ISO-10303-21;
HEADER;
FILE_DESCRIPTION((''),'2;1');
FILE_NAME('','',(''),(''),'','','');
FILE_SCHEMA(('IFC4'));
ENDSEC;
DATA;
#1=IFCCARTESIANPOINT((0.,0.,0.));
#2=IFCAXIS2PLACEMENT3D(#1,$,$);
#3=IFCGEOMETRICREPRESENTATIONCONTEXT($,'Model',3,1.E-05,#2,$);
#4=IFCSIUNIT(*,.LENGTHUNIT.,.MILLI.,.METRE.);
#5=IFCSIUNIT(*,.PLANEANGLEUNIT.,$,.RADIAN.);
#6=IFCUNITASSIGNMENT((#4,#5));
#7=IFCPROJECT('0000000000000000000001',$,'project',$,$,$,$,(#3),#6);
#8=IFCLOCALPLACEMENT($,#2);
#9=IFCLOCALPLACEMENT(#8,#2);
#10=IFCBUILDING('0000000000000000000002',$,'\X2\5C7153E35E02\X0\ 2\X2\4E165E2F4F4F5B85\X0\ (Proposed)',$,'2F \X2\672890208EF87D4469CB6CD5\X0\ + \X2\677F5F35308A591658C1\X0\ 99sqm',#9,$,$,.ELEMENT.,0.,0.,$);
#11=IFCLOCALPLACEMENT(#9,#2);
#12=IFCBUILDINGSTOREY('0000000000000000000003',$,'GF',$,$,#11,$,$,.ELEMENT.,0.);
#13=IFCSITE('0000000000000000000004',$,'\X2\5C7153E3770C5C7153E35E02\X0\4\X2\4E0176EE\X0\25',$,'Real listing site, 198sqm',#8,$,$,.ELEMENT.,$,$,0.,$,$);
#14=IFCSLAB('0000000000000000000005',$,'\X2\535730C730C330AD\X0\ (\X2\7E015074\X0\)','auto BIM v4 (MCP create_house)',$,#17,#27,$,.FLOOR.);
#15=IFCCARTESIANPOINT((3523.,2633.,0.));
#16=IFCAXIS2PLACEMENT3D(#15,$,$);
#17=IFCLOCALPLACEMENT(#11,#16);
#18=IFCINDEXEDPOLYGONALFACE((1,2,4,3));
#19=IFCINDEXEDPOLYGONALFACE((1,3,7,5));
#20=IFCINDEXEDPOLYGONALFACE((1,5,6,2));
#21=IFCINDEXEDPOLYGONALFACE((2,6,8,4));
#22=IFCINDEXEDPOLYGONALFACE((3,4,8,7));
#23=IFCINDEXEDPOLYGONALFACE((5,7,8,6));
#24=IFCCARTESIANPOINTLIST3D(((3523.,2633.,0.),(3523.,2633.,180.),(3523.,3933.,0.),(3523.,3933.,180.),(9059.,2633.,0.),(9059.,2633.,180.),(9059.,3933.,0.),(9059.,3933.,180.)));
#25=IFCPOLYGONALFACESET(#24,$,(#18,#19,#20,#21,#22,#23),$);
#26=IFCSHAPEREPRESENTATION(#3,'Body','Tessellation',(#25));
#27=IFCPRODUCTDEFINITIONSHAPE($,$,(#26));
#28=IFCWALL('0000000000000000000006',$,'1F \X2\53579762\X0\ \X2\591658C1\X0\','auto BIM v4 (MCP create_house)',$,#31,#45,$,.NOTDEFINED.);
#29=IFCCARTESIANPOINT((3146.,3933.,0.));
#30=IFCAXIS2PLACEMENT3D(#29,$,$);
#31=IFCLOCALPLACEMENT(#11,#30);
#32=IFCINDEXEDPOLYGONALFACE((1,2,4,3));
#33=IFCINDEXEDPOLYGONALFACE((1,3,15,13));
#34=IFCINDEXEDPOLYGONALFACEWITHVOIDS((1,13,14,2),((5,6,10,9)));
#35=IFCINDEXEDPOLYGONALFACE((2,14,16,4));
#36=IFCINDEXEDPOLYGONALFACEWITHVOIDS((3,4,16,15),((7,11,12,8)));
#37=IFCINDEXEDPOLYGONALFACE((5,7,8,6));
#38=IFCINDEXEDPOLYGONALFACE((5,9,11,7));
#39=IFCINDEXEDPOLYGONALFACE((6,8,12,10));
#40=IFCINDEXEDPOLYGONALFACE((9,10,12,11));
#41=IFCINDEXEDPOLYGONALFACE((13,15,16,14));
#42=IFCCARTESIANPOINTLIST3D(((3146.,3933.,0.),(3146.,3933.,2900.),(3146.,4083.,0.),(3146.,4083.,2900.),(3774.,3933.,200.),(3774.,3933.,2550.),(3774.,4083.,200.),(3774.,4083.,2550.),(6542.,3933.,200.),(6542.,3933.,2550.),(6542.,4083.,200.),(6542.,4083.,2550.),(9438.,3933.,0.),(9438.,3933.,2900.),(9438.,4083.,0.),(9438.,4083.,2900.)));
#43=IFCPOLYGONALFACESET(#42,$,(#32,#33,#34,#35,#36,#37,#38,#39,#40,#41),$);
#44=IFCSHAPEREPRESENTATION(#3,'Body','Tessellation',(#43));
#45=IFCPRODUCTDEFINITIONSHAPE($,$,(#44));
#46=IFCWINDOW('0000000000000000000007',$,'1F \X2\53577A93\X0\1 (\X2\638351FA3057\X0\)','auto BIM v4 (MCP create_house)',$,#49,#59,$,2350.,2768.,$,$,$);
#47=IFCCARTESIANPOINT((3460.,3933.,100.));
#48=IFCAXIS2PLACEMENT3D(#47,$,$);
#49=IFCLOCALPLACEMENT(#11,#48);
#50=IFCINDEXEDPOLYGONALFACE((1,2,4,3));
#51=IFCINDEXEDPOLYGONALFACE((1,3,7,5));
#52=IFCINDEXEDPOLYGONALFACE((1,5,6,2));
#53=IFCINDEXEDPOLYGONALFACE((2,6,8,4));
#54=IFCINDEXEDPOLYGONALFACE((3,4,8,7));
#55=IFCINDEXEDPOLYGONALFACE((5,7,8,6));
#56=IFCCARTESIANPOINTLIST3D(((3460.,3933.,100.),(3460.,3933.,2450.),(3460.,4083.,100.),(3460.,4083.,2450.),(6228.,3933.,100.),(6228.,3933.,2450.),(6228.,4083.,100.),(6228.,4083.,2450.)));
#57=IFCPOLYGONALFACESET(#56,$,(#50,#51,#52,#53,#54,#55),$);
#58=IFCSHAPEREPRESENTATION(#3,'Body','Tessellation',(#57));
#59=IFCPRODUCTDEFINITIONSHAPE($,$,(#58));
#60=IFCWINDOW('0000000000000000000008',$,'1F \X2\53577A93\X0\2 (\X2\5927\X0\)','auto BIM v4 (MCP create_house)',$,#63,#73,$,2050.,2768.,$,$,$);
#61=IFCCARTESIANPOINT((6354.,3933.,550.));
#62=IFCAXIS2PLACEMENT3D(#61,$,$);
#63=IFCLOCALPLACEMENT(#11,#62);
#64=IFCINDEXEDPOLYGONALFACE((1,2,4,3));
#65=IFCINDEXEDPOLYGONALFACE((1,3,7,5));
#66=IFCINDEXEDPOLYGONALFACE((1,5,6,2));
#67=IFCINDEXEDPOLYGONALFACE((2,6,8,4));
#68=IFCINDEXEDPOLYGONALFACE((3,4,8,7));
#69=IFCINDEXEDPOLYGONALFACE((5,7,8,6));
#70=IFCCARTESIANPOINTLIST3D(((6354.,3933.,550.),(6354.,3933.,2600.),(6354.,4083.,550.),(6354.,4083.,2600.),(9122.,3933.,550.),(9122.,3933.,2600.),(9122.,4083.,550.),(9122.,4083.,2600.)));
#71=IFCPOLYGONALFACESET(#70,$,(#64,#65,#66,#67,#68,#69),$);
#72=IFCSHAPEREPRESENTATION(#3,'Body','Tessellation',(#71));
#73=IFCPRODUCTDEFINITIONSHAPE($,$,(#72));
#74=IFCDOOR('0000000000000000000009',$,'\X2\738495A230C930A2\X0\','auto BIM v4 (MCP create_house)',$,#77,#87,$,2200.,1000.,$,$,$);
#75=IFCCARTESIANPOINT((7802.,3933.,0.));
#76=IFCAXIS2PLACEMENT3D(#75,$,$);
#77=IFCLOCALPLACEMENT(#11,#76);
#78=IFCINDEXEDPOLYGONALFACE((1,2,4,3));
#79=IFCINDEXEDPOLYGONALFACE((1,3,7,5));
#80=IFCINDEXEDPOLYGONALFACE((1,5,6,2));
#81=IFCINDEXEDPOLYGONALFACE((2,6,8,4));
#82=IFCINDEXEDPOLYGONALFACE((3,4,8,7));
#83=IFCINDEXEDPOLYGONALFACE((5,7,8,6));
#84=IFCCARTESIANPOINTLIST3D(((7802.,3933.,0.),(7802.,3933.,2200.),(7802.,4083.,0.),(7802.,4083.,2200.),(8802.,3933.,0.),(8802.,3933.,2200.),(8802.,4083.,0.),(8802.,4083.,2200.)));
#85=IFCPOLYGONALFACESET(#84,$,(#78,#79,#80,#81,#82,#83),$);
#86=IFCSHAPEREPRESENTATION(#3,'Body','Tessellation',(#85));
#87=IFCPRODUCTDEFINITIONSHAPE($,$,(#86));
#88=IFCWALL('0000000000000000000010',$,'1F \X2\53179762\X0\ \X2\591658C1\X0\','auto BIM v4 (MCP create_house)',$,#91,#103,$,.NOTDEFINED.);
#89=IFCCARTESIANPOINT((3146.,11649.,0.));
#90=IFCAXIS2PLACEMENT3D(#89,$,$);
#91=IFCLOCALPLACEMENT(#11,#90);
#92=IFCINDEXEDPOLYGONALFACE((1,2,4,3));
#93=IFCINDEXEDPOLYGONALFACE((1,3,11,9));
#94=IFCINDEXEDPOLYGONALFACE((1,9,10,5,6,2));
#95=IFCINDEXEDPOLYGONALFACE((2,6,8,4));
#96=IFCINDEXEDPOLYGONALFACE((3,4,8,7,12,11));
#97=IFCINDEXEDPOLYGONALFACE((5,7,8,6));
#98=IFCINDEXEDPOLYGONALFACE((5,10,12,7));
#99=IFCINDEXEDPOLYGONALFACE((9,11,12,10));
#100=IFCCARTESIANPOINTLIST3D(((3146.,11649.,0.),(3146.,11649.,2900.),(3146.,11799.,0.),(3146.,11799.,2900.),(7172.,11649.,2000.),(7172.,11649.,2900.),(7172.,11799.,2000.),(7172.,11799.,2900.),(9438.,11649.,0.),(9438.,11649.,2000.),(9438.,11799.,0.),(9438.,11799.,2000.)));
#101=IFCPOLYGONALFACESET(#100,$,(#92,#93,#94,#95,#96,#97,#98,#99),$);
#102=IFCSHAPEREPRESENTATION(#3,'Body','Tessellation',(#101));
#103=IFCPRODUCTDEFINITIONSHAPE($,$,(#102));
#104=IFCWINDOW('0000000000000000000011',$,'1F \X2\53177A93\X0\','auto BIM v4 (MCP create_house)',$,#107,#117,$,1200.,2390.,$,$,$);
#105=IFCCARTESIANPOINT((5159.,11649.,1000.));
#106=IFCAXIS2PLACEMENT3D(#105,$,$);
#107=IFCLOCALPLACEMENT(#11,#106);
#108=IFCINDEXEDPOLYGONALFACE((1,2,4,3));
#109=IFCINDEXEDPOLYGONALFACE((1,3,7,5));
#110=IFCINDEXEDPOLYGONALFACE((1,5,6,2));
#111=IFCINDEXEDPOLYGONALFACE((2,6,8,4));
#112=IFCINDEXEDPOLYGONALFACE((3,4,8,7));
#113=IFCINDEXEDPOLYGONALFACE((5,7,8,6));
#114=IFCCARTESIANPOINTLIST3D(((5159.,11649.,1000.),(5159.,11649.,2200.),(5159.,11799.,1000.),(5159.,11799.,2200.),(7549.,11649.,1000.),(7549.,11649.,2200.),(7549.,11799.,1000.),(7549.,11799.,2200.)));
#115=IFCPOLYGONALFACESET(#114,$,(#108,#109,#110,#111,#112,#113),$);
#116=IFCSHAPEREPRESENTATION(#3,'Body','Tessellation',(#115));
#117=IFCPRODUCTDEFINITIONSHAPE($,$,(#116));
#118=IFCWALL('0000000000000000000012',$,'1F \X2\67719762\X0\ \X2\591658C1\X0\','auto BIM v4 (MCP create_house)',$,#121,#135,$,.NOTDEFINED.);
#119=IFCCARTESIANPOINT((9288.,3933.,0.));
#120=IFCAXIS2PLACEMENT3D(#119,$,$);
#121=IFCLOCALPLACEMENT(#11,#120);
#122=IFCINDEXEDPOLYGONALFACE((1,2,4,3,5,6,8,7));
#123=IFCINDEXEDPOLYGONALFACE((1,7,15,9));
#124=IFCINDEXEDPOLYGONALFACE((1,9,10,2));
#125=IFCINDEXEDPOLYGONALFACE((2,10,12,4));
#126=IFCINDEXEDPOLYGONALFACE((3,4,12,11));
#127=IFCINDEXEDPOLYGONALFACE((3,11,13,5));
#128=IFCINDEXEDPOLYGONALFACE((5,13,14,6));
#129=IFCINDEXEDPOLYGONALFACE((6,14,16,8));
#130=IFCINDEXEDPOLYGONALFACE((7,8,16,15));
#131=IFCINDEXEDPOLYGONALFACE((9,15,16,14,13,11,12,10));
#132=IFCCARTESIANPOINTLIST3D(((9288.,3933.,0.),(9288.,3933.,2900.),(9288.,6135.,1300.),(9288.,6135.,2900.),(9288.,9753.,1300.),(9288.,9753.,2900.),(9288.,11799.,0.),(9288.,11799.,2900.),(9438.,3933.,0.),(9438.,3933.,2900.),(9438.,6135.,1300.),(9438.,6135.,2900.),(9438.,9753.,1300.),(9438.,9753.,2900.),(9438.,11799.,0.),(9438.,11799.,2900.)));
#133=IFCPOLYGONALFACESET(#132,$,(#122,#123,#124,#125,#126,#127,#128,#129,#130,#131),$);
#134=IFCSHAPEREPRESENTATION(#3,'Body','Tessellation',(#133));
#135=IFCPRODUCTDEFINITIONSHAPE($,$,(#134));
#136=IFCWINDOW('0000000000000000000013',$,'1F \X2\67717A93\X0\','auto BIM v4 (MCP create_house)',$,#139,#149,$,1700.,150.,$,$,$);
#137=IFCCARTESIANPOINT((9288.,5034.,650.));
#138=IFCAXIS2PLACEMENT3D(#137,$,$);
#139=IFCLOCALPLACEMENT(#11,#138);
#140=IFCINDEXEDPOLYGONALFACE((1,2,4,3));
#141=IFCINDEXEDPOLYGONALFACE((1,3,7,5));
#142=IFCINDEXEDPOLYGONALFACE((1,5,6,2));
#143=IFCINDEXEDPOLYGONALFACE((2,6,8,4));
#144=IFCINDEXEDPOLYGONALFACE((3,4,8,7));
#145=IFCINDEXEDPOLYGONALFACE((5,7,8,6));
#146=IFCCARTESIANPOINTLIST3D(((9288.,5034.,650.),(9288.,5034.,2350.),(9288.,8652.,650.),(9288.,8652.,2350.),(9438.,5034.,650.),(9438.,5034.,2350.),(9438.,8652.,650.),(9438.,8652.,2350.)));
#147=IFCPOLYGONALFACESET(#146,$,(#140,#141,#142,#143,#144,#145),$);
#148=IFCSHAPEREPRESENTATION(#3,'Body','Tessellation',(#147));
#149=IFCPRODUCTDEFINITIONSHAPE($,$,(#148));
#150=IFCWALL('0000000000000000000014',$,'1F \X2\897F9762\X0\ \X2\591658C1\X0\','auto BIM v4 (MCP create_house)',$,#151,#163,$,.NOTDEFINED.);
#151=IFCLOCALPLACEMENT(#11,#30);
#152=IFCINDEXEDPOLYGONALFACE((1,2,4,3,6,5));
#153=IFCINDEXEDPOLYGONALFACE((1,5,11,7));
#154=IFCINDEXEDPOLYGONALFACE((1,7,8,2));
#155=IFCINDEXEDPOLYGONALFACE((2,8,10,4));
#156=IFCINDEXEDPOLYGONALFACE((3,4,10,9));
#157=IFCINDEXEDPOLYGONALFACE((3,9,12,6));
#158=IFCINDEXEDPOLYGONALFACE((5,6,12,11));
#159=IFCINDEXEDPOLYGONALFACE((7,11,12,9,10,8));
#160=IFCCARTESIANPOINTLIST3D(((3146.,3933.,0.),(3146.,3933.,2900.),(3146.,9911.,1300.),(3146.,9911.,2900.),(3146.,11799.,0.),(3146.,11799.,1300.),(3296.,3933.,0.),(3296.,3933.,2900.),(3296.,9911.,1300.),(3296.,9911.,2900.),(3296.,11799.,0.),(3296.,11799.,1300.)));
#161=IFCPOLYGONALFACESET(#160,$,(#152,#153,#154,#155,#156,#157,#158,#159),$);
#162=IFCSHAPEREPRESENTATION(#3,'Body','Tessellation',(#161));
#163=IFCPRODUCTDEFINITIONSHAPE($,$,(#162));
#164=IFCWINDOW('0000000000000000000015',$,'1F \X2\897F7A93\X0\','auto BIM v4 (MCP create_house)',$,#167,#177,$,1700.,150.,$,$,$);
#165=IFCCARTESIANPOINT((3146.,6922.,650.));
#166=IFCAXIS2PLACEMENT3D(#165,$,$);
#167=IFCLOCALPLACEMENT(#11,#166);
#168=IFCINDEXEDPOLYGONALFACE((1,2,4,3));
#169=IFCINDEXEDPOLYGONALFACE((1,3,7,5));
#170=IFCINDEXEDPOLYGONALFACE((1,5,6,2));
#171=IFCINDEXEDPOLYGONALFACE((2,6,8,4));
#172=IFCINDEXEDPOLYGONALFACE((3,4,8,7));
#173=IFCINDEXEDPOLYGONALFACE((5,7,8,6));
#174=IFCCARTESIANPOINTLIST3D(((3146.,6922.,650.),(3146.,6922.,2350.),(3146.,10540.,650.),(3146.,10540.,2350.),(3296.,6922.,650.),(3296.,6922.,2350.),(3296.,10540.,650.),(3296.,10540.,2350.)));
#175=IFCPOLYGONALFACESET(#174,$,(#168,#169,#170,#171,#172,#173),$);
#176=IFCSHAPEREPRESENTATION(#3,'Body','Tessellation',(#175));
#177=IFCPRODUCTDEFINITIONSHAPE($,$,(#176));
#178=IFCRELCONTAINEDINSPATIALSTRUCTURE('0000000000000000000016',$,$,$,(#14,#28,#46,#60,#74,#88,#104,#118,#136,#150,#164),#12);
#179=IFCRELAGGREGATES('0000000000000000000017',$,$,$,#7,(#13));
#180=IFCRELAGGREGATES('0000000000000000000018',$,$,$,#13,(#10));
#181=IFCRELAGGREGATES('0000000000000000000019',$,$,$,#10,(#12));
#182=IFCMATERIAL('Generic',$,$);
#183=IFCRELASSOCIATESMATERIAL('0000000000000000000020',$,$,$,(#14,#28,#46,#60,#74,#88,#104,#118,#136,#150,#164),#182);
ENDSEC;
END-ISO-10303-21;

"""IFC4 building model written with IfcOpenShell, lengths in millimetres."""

from ifc_helpers import new_model, si_unit, frame, frame_2d, origin, place, context, project, spatial, rectangle, extrude, material, element, fill, save


model = new_model("IFC4")

# Units and contexts
model_context = context("Model", 3, precision=1e-05, world=origin())
ifc_project = project(units=[si_unit("LENGTHUNIT", "METRE", prefix="MILLI"), si_unit("PLANEANGLEUNIT", "RADIAN")], contexts=[model_context])

# Site, building, storey
site_placement = place(None, origin())
site = spatial("IfcSite", under=ifc_project, at=site_placement, Name="山口県山口市4丁目25", ObjectType="Real listing site, 198sqm", CompositionType="ELEMENT", RefElevation=0.0)
building_placement = place(site_placement, origin())
building = spatial("IfcBuilding", under=site, at=building_placement, Name="山口市 2世帯住宅 (Proposed)", ObjectType="2F 木造軸組構法 + 板張り外壁 99sqm", CompositionType="ELEMENT", ElevationOfRefHeight=0.0, ElevationOfTerrain=0.0)
storey_placement = place(building_placement, origin())
storey = spatial("IfcBuildingStorey", under=building, at=storey_placement, Name="GF", CompositionType="ELEMENT", Elevation=0.0)

# Slab
ifc_material = material(Name="Generic")
slab_1_placement = place(storey_placement, frame((3523.0, 2633.0, 0.0)))
element("IfcSlab", 1, at=slab_1_placement, inside=storey, material=ifc_material, Name="南デッキ (縁側)", Description="auto BIM v4 (MCP create_house)", PredefinedType="FLOOR", context=model_context, shape_type="SweptSolid", body=[
    extrude(rectangle(XDim=5536.0, YDim=1300.0, at=frame_2d((2768.0, 650.0))), frame((3523.0, 2633.0, 0.0)), (0.0, 0.0, 1.0), 180.0),
])

# Wall, openings, windows, door
wall_1_placement = place(storey_placement, frame((3146.0, 3933.0, 0.0)))
wall_1 = element("IfcWall", 2, at=wall_1_placement, inside=storey, material=ifc_material, Name="1F 南面 外壁", Description="auto BIM v4 (MCP create_house)", PredefinedType="NOTDEFINED", context=model_context, shape_type="SweptSolid", body=[
    extrude(rectangle(XDim=6292.0, YDim=150.0, at=frame_2d((3146.0, 75.0))), frame((3146.0, 3933.0, 0.0)), (0.0, 0.0, 1.0), 2900.0),
])
opening_1_placement = place(storey_placement, frame((3460.0, 3933.0, 100.0)))
opening_1 = element("IfcOpeningElement", 3, at=opening_1_placement, cuts=wall_1, PredefinedType="NOTDEFINED", context=model_context, shape_type="SweptSolid", body=[
    extrude(rectangle(XDim=2768.0, YDim=150.0, at=frame_2d((1384.0, 75.0))), frame((3460.0, 3933.0, 100.0)), (0.0, 0.0, 1.0), 2350.0),
])
opening_2_placement = place(storey_placement, frame((6354.0, 3933.0, 550.0)))
opening_2 = element("IfcOpeningElement", 4, at=opening_2_placement, cuts=wall_1, PredefinedType="NOTDEFINED", context=model_context, shape_type="SweptSolid", body=[
    extrude(rectangle(XDim=2768.0, YDim=150.0, at=frame_2d((1384.0, 75.0))), frame((6354.0, 3933.0, 550.0)), (0.0, 0.0, 1.0), 2050.0),
])
opening_3_placement = place(storey_placement, frame((7802.0, 3933.0, 0.0)))
opening_3 = element("IfcOpeningElement", 5, at=opening_3_placement, cuts=wall_1, PredefinedType="NOTDEFINED", context=model_context, shape_type="SweptSolid", body=[
    extrude(rectangle(XDim=1000.0, YDim=150.0, at=frame_2d((500.0, 75.0))), frame((7802.0, 3933.0, 0.0)), (0.0, 0.0, 1.0), 2200.0),
])
window_1_placement = place(storey_placement, frame((3460.0, 3933.0, 100.0)))
window_1 = element("IfcWindow", 6, at=window_1_placement, inside=storey, material=ifc_material, Name="1F 南窓1 (掃出し)", Description="auto BIM v4 (MCP create_house)", OverallHeight=2350.0, OverallWidth=2768.0, context=model_context, shape_type="SweptSolid", body=[
    extrude(rectangle(XDim=2768.0, YDim=150.0, at=frame_2d((1384.0, 75.0))), frame((3460.0, 3933.0, 100.0)), (0.0, 0.0, 1.0), 2350.0),
])
fill(opening_1, window_1)
window_2_placement = place(storey_placement, frame((6354.0, 3933.0, 550.0)))
window_2 = element("IfcWindow", 7, at=window_2_placement, inside=storey, material=ifc_material, Name="1F 南窓2 (大)", Description="auto BIM v4 (MCP create_house)", OverallHeight=2050.0, OverallWidth=2768.0, context=model_context, shape_type="SweptSolid", body=[
    extrude(rectangle(XDim=2768.0, YDim=150.0, at=frame_2d((1384.0, 75.0))), frame((6354.0, 3933.0, 550.0)), (0.0, 0.0, 1.0), 2050.0),
])
fill(opening_2, window_2)
door_1_placement = place(storey_placement, frame((7802.0, 3933.0, 0.0)))
door_1 = element("IfcDoor", 8, at=door_1_placement, inside=storey, material=ifc_material, Name="玄関ドア", Description="auto BIM v4 (MCP create_house)", OverallHeight=2200.0, OverallWidth=1000.0, context=model_context, shape_type="SweptSolid", body=[
    extrude(rectangle(XDim=1000.0, YDim=150.0, at=frame_2d((500.0, 75.0))), frame((7802.0, 3933.0, 0.0)), (0.0, 0.0, 1.0), 2200.0),
])
fill(opening_3, door_1)

# Walls, openings, windows
wall_2_placement = place(storey_placement, frame((3146.0, 11649.0, 0.0)))
wall_2 = element("IfcWall", 9, at=wall_2_placement, inside=storey, material=ifc_material, Name="1F 北面 外壁", Description="auto BIM v4 (MCP create_house)", PredefinedType="NOTDEFINED", context=model_context, shape_type="SweptSolid", body=[
    extrude(rectangle(XDim=6292.0, YDim=150.0, at=frame_2d((3146.0, 75.0))), frame((3146.0, 11649.0, 0.0)), (0.0, 0.0, 1.0), 2900.0),
])
opening_4_placement = place(storey_placement, frame((5159.0, 11649.0, 1000.0)))
opening_4 = element("IfcOpeningElement", 10, at=opening_4_placement, cuts=wall_2, PredefinedType="NOTDEFINED", context=model_context, shape_type="SweptSolid", body=[
    extrude(rectangle(XDim=2390.0, YDim=150.0, at=frame_2d((1195.0, 75.0))), frame((5159.0, 11649.0, 1000.0)), (0.0, 0.0, 1.0), 1200.0),
])
window_3_placement = place(storey_placement, frame((5159.0, 11649.0, 1000.0)))
window_3 = element("IfcWindow", 11, at=window_3_placement, inside=storey, material=ifc_material, Name="1F 北窓", Description="auto BIM v4 (MCP create_house)", OverallHeight=1200.0, OverallWidth=2390.0, context=model_context, shape_type="SweptSolid", body=[
    extrude(rectangle(XDim=2390.0, YDim=150.0, at=frame_2d((1195.0, 75.0))), frame((5159.0, 11649.0, 1000.0)), (0.0, 0.0, 1.0), 1200.0),
])
fill(opening_4, window_3)
wall_3_placement = place(storey_placement, frame((9288.0, 3933.0, 0.0)))
wall_3 = element("IfcWall", 12, at=wall_3_placement, inside=storey, material=ifc_material, Name="1F 東面 外壁", Description="auto BIM v4 (MCP create_house)", PredefinedType="NOTDEFINED", context=model_context, shape_type="SweptSolid", body=[
    extrude(rectangle(XDim=150.0, YDim=7866.0, at=frame_2d((75.0, 3933.0))), frame((9288.0, 3933.0, 0.0)), (0.0, 0.0, 1.0), 2900.0),
])
opening_5_placement = place(storey_placement, frame((9288.0, 5034.0, 650.0)))
opening_5 = element("IfcOpeningElement", 13, at=opening_5_placement, cuts=wall_3, PredefinedType="NOTDEFINED", context=model_context, shape_type="SweptSolid", body=[
    extrude(rectangle(XDim=150.0, YDim=3618.0, at=frame_2d((75.0, 1809.0))), frame((9288.0, 5034.0, 650.0)), (0.0, 0.0, 1.0), 1700.0),
])
window_4_placement = place(storey_placement, frame((9288.0, 5034.0, 650.0)))
window_4 = element("IfcWindow", 14, at=window_4_placement, inside=storey, material=ifc_material, Name="1F 東窓", Description="auto BIM v4 (MCP create_house)", OverallHeight=1700.0, OverallWidth=150.0, context=model_context, shape_type="SweptSolid", body=[
    extrude(rectangle(XDim=150.0, YDim=3618.0, at=frame_2d((75.0, 1809.0))), frame((9288.0, 5034.0, 650.0)), (0.0, 0.0, 1.0), 1700.0),
])
fill(opening_5, window_4)
wall_4_placement = place(storey_placement, frame((3146.0, 3933.0, 0.0)))
wall_4 = element("IfcWall", 15, at=wall_4_placement, inside=storey, material=ifc_material, Name="1F 西面 外壁", Description="auto BIM v4 (MCP create_house)", PredefinedType="NOTDEFINED", context=model_context, shape_type="SweptSolid", body=[
    extrude(rectangle(XDim=150.0, YDim=7866.0, at=frame_2d((75.0, 3933.0))), frame((3146.0, 3933.0, 0.0)), (0.0, 0.0, 1.0), 2900.0),
])
opening_6_placement = place(storey_placement, frame((3146.0, 6922.0, 650.0)))
opening_6 = element("IfcOpeningElement", 16, at=opening_6_placement, cuts=wall_4, PredefinedType="NOTDEFINED", context=model_context, shape_type="SweptSolid", body=[
    extrude(rectangle(XDim=150.0, YDim=3618.0, at=frame_2d((75.0, 1809.0))), frame((3146.0, 6922.0, 650.0)), (0.0, 0.0, 1.0), 1700.0),
])
window_5_placement = place(storey_placement, frame((3146.0, 6922.0, 650.0)))
window_5 = element("IfcWindow", 17, at=window_5_placement, inside=storey, material=ifc_material, Name="1F 西窓", Description="auto BIM v4 (MCP create_house)", OverallHeight=1700.0, OverallWidth=150.0, context=model_context, shape_type="SweptSolid", body=[
    extrude(rectangle(XDim=150.0, YDim=3618.0, at=frame_2d((75.0, 1809.0))), frame((3146.0, 6922.0, 650.0)), (0.0, 0.0, 1.0), 1700.0),
])
fill(opening_6, window_5)

save(model, "model.ifc")
